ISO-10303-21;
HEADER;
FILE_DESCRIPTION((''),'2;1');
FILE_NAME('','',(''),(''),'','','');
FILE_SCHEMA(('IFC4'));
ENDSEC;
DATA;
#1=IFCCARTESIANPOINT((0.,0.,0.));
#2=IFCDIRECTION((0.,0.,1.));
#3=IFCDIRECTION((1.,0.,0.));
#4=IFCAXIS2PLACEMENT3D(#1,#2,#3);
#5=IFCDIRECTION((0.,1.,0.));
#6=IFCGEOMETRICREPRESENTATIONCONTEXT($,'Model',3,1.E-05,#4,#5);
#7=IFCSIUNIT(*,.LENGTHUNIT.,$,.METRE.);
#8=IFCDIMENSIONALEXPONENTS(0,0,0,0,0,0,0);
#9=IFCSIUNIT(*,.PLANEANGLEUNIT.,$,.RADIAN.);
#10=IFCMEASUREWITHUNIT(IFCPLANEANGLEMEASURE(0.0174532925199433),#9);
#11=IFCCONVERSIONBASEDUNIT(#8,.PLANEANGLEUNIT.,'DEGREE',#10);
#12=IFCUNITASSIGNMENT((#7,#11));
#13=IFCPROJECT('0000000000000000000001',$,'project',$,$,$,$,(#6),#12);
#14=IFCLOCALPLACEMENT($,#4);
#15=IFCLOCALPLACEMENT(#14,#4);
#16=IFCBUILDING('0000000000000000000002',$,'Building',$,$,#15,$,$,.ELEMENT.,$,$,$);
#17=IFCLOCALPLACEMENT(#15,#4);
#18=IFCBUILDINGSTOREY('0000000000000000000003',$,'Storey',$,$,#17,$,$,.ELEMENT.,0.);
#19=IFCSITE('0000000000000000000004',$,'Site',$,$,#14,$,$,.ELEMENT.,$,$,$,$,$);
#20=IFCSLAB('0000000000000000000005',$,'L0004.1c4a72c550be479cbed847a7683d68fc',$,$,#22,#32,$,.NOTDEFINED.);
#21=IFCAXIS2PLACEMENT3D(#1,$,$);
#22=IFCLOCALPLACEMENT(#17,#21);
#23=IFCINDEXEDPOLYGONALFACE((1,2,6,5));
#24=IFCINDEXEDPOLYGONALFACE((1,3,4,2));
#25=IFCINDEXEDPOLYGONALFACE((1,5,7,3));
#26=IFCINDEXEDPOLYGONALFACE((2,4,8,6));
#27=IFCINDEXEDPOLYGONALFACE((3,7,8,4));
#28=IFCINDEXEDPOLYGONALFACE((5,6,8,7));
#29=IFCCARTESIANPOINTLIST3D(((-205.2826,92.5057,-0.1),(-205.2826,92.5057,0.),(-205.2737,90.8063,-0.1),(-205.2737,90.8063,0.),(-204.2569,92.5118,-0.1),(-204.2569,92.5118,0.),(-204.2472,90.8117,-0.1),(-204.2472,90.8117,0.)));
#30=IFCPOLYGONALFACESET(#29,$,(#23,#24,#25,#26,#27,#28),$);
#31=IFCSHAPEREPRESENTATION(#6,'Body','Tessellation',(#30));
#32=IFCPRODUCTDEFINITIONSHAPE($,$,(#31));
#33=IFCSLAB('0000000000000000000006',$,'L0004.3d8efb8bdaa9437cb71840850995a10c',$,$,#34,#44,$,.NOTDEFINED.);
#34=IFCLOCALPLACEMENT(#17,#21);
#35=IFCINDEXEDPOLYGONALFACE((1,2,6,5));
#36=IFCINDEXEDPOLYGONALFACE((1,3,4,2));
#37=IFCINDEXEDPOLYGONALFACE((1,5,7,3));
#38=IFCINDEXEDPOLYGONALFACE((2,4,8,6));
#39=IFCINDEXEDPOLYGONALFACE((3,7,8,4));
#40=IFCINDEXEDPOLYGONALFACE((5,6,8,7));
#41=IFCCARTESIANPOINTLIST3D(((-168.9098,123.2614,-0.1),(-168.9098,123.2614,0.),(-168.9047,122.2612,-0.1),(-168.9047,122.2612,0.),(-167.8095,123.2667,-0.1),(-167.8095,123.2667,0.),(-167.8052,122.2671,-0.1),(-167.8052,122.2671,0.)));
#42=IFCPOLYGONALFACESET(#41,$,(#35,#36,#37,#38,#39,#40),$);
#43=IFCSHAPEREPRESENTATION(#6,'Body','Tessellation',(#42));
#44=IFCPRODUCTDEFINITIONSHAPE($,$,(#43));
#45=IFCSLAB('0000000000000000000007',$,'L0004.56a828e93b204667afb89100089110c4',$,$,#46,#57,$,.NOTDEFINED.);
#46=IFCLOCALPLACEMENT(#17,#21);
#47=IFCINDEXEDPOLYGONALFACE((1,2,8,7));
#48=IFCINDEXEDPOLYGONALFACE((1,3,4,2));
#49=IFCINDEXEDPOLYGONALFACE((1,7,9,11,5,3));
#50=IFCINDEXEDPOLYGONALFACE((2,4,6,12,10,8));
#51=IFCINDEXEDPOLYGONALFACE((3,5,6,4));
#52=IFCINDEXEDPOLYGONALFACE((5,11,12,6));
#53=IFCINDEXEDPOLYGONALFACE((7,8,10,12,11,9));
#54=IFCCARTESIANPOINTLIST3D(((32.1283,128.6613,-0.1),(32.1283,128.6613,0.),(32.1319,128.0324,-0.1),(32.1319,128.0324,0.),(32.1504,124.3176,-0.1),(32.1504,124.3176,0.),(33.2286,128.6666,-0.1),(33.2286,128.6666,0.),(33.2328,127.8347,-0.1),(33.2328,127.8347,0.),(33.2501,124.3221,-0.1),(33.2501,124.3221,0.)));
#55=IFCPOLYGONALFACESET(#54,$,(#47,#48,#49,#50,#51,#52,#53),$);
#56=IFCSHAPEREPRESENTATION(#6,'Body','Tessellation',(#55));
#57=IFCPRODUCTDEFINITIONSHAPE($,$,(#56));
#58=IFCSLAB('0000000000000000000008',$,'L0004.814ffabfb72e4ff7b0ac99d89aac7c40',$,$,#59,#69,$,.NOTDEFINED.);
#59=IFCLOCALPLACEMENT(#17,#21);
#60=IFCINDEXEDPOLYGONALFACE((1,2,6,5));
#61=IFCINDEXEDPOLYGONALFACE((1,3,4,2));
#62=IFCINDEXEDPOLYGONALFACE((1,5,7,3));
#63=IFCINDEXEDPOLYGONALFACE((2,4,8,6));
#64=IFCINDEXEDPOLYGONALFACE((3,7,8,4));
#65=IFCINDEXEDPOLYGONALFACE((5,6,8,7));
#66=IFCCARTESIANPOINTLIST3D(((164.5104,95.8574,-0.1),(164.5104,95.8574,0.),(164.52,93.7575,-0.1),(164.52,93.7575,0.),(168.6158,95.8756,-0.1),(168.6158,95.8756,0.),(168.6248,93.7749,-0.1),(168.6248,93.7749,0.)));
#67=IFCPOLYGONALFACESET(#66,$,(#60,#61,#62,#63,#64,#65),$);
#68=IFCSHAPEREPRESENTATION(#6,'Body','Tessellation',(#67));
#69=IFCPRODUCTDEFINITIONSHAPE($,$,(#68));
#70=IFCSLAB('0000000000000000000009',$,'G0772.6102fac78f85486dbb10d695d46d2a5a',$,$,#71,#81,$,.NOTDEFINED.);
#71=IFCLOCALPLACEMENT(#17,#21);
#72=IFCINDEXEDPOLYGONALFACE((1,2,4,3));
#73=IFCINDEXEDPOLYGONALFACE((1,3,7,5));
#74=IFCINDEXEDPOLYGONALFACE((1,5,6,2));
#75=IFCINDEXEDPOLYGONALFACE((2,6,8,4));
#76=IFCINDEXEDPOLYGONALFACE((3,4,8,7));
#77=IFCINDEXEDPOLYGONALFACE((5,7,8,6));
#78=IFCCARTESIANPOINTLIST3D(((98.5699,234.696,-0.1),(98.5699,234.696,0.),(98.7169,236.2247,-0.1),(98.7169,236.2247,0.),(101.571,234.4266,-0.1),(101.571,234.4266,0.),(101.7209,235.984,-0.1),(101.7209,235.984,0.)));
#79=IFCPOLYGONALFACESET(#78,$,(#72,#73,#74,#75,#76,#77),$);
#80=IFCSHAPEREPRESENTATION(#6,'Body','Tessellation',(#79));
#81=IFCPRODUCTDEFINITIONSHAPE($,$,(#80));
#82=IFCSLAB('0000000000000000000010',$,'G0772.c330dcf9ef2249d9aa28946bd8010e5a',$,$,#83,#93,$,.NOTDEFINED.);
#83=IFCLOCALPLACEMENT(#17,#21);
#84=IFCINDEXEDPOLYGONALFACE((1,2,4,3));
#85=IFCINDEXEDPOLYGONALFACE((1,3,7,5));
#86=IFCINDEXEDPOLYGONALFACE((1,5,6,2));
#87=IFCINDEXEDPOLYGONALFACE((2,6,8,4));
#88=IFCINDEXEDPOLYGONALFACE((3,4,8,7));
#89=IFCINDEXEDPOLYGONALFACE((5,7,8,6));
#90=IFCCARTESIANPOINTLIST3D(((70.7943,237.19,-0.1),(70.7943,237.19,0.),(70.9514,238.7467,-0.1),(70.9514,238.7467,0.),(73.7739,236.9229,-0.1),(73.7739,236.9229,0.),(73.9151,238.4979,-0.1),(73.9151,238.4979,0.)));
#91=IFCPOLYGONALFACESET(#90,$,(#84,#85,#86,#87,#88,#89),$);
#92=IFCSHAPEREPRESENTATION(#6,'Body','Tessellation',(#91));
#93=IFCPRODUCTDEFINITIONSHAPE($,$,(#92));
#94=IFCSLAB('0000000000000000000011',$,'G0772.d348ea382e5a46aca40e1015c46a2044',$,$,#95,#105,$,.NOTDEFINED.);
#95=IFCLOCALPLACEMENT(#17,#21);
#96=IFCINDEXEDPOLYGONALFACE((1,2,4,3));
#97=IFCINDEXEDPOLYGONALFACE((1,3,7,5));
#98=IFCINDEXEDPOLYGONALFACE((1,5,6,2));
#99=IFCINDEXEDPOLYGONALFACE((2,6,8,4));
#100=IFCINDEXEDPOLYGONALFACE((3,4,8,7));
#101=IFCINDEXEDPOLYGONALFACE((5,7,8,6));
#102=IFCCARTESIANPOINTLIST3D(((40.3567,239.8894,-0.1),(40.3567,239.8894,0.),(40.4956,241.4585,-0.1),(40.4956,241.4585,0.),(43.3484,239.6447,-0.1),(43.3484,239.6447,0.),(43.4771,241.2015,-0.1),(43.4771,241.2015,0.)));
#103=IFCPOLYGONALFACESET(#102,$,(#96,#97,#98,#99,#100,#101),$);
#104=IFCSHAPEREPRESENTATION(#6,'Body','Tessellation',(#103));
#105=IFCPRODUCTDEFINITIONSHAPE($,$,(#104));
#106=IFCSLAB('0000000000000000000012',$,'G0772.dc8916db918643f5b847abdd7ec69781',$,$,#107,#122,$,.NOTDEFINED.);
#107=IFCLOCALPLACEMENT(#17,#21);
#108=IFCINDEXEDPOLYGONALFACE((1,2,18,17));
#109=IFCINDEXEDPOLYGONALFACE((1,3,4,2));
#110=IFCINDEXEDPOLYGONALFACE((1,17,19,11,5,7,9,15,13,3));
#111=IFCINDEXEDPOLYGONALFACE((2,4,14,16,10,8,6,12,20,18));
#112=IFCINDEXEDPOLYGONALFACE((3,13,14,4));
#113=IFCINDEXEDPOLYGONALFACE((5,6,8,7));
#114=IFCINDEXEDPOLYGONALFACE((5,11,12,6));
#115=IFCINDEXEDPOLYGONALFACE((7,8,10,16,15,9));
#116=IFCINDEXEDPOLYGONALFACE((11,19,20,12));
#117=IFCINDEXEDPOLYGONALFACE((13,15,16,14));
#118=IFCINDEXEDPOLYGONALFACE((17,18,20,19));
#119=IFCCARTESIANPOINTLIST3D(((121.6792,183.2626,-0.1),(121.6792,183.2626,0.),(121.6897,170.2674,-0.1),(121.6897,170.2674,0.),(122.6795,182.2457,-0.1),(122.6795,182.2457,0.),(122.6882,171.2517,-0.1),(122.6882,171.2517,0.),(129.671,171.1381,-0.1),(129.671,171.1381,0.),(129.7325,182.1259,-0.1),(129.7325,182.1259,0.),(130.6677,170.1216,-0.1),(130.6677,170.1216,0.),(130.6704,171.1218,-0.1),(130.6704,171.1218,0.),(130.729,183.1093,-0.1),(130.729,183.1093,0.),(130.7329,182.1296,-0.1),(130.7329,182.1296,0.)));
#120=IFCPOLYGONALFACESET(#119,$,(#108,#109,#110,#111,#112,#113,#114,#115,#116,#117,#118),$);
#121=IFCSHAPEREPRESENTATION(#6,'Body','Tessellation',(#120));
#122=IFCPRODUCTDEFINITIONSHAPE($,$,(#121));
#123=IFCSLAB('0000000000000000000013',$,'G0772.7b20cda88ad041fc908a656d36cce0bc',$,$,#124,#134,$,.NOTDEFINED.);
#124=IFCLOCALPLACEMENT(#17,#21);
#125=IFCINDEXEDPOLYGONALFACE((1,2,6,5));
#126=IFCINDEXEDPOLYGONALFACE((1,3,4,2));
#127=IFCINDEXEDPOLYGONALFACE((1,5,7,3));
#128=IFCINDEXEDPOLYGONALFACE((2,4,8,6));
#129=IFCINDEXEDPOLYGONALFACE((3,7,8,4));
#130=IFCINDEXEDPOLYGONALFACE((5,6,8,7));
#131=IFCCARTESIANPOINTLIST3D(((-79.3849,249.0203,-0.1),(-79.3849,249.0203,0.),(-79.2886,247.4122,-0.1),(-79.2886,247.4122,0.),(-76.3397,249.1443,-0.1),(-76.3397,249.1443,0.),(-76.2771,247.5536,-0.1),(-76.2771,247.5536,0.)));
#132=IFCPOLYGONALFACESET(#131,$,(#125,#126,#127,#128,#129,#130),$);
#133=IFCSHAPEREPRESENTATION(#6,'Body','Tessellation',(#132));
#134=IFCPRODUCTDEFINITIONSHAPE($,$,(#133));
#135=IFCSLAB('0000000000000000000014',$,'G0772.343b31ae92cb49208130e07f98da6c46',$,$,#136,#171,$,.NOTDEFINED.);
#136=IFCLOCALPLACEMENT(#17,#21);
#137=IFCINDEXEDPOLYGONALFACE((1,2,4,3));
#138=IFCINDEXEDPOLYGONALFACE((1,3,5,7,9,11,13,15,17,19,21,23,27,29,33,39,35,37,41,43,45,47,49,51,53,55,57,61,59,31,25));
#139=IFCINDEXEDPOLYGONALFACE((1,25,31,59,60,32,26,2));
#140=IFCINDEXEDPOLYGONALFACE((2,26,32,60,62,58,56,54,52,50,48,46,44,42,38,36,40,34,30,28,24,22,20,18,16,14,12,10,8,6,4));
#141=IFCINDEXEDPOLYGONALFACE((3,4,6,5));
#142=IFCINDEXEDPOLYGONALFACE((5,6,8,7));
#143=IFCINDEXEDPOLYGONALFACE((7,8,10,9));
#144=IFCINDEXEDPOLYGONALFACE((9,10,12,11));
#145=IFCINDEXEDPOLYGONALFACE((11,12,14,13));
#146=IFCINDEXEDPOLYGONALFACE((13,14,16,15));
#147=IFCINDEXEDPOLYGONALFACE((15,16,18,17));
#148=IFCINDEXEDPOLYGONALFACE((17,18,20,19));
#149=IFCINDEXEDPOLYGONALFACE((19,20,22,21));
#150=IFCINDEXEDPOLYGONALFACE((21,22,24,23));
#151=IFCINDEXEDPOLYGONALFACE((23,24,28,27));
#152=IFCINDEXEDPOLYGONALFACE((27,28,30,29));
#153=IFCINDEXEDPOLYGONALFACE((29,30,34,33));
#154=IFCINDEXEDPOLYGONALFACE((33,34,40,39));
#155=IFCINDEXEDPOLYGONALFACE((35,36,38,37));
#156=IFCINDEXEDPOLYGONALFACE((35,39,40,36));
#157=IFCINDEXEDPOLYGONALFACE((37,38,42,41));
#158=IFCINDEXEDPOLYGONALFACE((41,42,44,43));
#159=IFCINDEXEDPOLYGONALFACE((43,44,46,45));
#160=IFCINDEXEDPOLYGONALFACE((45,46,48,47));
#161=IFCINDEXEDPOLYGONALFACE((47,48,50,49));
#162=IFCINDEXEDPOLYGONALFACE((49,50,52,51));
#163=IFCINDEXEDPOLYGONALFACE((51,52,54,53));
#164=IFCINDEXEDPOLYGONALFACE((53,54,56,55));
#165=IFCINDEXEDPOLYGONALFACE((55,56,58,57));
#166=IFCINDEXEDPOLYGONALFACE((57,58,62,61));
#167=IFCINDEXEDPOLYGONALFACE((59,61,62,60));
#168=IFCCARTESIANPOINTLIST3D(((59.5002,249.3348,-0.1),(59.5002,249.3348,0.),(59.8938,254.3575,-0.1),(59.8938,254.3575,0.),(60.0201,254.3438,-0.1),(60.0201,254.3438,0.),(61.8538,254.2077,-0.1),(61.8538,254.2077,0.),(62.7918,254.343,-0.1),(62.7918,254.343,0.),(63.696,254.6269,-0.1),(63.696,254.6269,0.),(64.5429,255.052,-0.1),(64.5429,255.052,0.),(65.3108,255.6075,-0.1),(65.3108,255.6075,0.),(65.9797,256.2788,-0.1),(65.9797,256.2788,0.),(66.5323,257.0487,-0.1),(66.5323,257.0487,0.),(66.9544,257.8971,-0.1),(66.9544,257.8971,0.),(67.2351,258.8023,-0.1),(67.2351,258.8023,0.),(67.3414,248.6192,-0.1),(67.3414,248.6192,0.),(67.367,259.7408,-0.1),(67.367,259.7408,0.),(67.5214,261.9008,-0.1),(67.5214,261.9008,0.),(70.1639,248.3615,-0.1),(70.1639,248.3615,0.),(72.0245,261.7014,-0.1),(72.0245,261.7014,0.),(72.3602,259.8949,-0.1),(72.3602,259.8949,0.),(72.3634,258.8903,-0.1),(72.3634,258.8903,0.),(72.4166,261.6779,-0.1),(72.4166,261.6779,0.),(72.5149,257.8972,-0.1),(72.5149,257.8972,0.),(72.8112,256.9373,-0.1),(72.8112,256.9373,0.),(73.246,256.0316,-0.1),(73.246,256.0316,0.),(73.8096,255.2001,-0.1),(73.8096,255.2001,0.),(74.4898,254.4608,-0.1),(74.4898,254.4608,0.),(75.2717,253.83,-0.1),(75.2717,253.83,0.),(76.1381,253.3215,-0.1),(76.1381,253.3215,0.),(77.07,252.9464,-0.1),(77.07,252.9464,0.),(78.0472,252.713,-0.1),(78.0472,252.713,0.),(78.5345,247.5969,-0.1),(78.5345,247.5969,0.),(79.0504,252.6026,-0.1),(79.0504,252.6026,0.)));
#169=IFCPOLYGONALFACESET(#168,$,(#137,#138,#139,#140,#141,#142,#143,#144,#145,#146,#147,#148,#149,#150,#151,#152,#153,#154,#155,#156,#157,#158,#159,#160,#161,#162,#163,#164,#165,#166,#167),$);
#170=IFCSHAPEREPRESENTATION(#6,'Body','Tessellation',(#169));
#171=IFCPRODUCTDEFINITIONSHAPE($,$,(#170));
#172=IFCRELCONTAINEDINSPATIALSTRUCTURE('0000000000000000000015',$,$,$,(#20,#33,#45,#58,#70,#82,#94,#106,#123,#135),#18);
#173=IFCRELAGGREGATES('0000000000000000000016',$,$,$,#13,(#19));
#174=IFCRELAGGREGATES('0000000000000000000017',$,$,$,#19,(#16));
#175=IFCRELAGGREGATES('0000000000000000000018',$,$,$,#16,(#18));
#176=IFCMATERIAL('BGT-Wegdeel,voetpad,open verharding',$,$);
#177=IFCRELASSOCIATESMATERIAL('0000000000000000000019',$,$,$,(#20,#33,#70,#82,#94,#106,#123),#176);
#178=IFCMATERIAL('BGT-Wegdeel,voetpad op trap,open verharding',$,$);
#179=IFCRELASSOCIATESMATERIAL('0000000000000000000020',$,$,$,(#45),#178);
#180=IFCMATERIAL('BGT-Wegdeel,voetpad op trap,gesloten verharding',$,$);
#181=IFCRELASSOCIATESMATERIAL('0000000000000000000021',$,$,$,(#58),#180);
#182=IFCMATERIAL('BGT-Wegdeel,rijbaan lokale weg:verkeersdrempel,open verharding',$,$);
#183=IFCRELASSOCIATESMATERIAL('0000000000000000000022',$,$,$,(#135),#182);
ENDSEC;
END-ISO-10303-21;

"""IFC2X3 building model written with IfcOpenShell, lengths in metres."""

from ifc_helpers import new_model, entity, si_unit, converted_unit, direction, frame, origin_with_axes, place, context, project, spatial, polyline, outline, extrude, material, element, save


model = new_model("IFC2X3")

# Units and contexts
model_context = context("Model", 3, precision=1e-05, world=origin_with_axes(), true_north=direction((0.0, 1.0, 0.0)))
ifc_project = project(units=[si_unit("LENGTHUNIT", "METRE"), converted_unit("PLANEANGLEUNIT", "DEGREE", entity("IfcPlaneAngleMeasure", 0.0174532925199433), si_unit("PLANEANGLEUNIT", "RADIAN"), dimensions=[0, 0, 0, 0, 0, 0, 0])], contexts=[model_context])

# Site, building, storey
site_placement = place(None, origin_with_axes())
site = spatial("IfcSite", under=ifc_project, at=site_placement, Name="Site", CompositionType="ELEMENT")
building_placement = place(site_placement, origin_with_axes())
building = spatial("IfcBuilding", under=site, at=building_placement, Name="Building", CompositionType="ELEMENT")
storey_placement = place(building_placement, origin_with_axes())
storey = spatial("IfcBuildingStorey", under=building, at=storey_placement, Name="Storey", CompositionType="ELEMENT", Elevation=0.0)

# Slabs
ifc_material_1 = material(Name="BGT-Wegdeel,voetpad,open verharding")
slab_1_placement = place(storey_placement, frame((0.0, 0.0, -0.1), z_axis=(0.0, 0.0, 1.0), x_axis=(1.0, 0.0, 0.0)))
element("IfcSlab", 1, at=slab_1_placement, inside=storey, material=ifc_material_1, Name="L0004.1c4a72c550be479cbed847a7683d68fc", PredefinedType="NOTDEFINED", context=model_context, shape_type="SweptSolid", body=[
    extrude(outline(polyline([(-205.2826, 92.5057), (-204.2569, 92.5118), (-204.2472, 90.8117), (-205.2737, 90.8063), (-205.2826, 92.5057)])), origin_with_axes(), (0.0, 0.0, 1.0), 0.1),
])
slab_2_placement = place(storey_placement, frame((0.0, 0.0, -0.1), z_axis=(0.0, 0.0, 1.0), x_axis=(1.0, 0.0, 0.0)))
element("IfcSlab", 2, at=slab_2_placement, inside=storey, material=ifc_material_1, Name="L0004.3d8efb8bdaa9437cb71840850995a10c", PredefinedType="NOTDEFINED", context=model_context, shape_type="SweptSolid", body=[
    extrude(outline(polyline([(-167.8095, 123.2667), (-167.8052, 122.2671), (-168.9047, 122.2612), (-168.9098, 123.2614), (-167.8095, 123.2667)])), origin_with_axes(), (0.0, 0.0, 1.0), 0.1),
])
ifc_material_2 = material(Name="BGT-Wegdeel,voetpad op trap,open verharding")
slab_3_placement = place(storey_placement, frame((0.0, 0.0, -0.1), z_axis=(0.0, 0.0, 1.0), x_axis=(1.0, 0.0, 0.0)))
element("IfcSlab", 3, at=slab_3_placement, inside=storey, material=ifc_material_2, Name="L0004.56a828e93b204667afb89100089110c4", PredefinedType="NOTDEFINED", context=model_context, shape_type="SweptSolid", body=[
    extrude(outline(polyline([(32.1504, 124.3176), (32.1319, 128.0324), (32.1283, 128.6613), (33.2286, 128.6666), (33.2328, 127.8347), (33.2501, 124.3221), (32.1504, 124.3176)])), origin_with_axes(), (0.0, 0.0, 1.0), 0.1),
])
ifc_material_3 = material(Name="BGT-Wegdeel,voetpad op trap,gesloten verharding")
slab_4_placement = place(storey_placement, frame((0.0, 0.0, -0.1), z_axis=(0.0, 0.0, 1.0), x_axis=(1.0, 0.0, 0.0)))
element("IfcSlab", 4, at=slab_4_placement, inside=storey, material=ifc_material_3, Name="L0004.814ffabfb72e4ff7b0ac99d89aac7c40", PredefinedType="NOTDEFINED", context=model_context, shape_type="SweptSolid", body=[
    extrude(outline(polyline([(164.5104, 95.8574), (168.6158, 95.8756), (168.6248, 93.7749), (164.52, 93.7575), (164.5104, 95.8574)])), origin_with_axes(), (0.0, 0.0, 1.0), 0.1),
])
slab_5_placement = place(storey_placement, frame((0.0, 0.0, -0.1), z_axis=(0.0, 0.0, 1.0), x_axis=(1.0, 0.0, 0.0)))
element("IfcSlab", 5, at=slab_5_placement, inside=storey, material=ifc_material_1, Name="G0772.6102fac78f85486dbb10d695d46d2a5a", PredefinedType="NOTDEFINED", context=model_context, shape_type="SweptSolid", body=[
    extrude(outline(polyline([(98.7169, 236.2247), (101.7209, 235.984), (101.571, 234.4266), (98.5699, 234.696), (98.7169, 236.2247)])), origin_with_axes(), (0.0, 0.0, 1.0), 0.1),
])
slab_6_placement = place(storey_placement, frame((0.0, 0.0, -0.1), z_axis=(0.0, 0.0, 1.0), x_axis=(1.0, 0.0, 0.0)))
element("IfcSlab", 6, at=slab_6_placement, inside=storey, material=ifc_material_1, Name="G0772.c330dcf9ef2249d9aa28946bd8010e5a", PredefinedType="NOTDEFINED", context=model_context, shape_type="SweptSolid", body=[
    extrude(outline(polyline([(70.7943, 237.19), (70.9514, 238.7467), (73.9151, 238.4979), (73.7739, 236.9229), (70.7943, 237.19)])), origin_with_axes(), (0.0, 0.0, 1.0), 0.1),
])
slab_7_placement = place(storey_placement, frame((0.0, 0.0, -0.1), z_axis=(0.0, 0.0, 1.0), x_axis=(1.0, 0.0, 0.0)))
element("IfcSlab", 7, at=slab_7_placement, inside=storey, material=ifc_material_1, Name="G0772.d348ea382e5a46aca40e1015c46a2044", PredefinedType="NOTDEFINED", context=model_context, shape_type="SweptSolid", body=[
    extrude(outline(polyline([(40.4956, 241.4585), (43.4771, 241.2015), (43.3484, 239.6447), (40.3567, 239.8894), (40.4956, 241.4585)])), origin_with_axes(), (0.0, 0.0, 1.0), 0.1),
])
slab_8_placement = place(storey_placement, frame((0.0, 0.0, -0.1), z_axis=(0.0, 0.0, 1.0), x_axis=(1.0, 0.0, 0.0)))
element("IfcSlab", 8, at=slab_8_placement, inside=storey, material=ifc_material_1, Name="G0772.dc8916db918643f5b847abdd7ec69781", PredefinedType="NOTDEFINED", context=model_context, shape_type="SweptSolid", body=[
    extrude(outline(polyline([(130.729, 183.1093), (130.7329, 182.1296), (129.7325, 182.1259), (122.6795, 182.2457), (122.6882, 171.2517), (129.671, 171.1381), (130.6704, 171.1218), (130.6677, 170.1216), (121.6897, 170.2674), (121.6792, 183.2626), (130.729, 183.1093)])), origin_with_axes(), (0.0, 0.0, 1.0), 0.1),
])
slab_9_placement = place(storey_placement, frame((0.0, 0.0, -0.1), z_axis=(0.0, 0.0, 1.0), x_axis=(1.0, 0.0, 0.0)))
element("IfcSlab", 9, at=slab_9_placement, inside=storey, material=ifc_material_1, Name="G0772.7b20cda88ad041fc908a656d36cce0bc", PredefinedType="NOTDEFINED", context=model_context, shape_type="SweptSolid", body=[
    extrude(outline(polyline([(-76.3397, 249.1443), (-76.2771, 247.5536), (-79.2886, 247.4122), (-79.3849, 249.0203), (-76.3397, 249.1443)])), origin_with_axes(), (0.0, 0.0, 1.0), 0.1),
])
ifc_material_4 = material(Name="BGT-Wegdeel,rijbaan lokale weg:verkeersdrempel,open verharding")
slab_10_placement = place(storey_placement, frame((0.0, 0.0, -0.1), z_axis=(0.0, 0.0, 1.0), x_axis=(1.0, 0.0, 0.0)))
element("IfcSlab", 10, at=slab_10_placement, inside=storey, material=ifc_material_4, Name="G0772.343b31ae92cb49208130e07f98da6c46", PredefinedType="NOTDEFINED", context=model_context, shape_type="SweptSolid", body=[
    extrude(outline(polyline([(72.3602, 259.8949), (72.3634, 258.8903), (72.5149, 257.8972), (72.8112, 256.9373), (73.246, 256.0316), (73.8096, 255.2001), (74.4898, 254.4608), (75.2717, 253.83), (76.1381, 253.3215), (77.07, 252.9464), (78.0472, 252.713), (79.0504, 252.6026), (78.5345, 247.5969), (70.1639, 248.3615), (67.3414, 248.6192), (59.5002, 249.3348), (59.8938, 254.3575), (60.0201, 254.3438), (61.8538, 254.2077), (62.7918, 254.343), (63.696, 254.6269), (64.5429, 255.052), (65.3108, 255.6075), (65.9797, 256.2788), (66.5323, 257.0487), (66.9544, 257.8971), (67.2351, 258.8023), (67.367, 259.7408), (67.5214, 261.9008), (72.0245, 261.7014), (72.4166, 261.6779), (72.3602, 259.8949)])), origin_with_axes(), (0.0, 0.0, 1.0), 0.1),
])

save(model, "model.ifc")
